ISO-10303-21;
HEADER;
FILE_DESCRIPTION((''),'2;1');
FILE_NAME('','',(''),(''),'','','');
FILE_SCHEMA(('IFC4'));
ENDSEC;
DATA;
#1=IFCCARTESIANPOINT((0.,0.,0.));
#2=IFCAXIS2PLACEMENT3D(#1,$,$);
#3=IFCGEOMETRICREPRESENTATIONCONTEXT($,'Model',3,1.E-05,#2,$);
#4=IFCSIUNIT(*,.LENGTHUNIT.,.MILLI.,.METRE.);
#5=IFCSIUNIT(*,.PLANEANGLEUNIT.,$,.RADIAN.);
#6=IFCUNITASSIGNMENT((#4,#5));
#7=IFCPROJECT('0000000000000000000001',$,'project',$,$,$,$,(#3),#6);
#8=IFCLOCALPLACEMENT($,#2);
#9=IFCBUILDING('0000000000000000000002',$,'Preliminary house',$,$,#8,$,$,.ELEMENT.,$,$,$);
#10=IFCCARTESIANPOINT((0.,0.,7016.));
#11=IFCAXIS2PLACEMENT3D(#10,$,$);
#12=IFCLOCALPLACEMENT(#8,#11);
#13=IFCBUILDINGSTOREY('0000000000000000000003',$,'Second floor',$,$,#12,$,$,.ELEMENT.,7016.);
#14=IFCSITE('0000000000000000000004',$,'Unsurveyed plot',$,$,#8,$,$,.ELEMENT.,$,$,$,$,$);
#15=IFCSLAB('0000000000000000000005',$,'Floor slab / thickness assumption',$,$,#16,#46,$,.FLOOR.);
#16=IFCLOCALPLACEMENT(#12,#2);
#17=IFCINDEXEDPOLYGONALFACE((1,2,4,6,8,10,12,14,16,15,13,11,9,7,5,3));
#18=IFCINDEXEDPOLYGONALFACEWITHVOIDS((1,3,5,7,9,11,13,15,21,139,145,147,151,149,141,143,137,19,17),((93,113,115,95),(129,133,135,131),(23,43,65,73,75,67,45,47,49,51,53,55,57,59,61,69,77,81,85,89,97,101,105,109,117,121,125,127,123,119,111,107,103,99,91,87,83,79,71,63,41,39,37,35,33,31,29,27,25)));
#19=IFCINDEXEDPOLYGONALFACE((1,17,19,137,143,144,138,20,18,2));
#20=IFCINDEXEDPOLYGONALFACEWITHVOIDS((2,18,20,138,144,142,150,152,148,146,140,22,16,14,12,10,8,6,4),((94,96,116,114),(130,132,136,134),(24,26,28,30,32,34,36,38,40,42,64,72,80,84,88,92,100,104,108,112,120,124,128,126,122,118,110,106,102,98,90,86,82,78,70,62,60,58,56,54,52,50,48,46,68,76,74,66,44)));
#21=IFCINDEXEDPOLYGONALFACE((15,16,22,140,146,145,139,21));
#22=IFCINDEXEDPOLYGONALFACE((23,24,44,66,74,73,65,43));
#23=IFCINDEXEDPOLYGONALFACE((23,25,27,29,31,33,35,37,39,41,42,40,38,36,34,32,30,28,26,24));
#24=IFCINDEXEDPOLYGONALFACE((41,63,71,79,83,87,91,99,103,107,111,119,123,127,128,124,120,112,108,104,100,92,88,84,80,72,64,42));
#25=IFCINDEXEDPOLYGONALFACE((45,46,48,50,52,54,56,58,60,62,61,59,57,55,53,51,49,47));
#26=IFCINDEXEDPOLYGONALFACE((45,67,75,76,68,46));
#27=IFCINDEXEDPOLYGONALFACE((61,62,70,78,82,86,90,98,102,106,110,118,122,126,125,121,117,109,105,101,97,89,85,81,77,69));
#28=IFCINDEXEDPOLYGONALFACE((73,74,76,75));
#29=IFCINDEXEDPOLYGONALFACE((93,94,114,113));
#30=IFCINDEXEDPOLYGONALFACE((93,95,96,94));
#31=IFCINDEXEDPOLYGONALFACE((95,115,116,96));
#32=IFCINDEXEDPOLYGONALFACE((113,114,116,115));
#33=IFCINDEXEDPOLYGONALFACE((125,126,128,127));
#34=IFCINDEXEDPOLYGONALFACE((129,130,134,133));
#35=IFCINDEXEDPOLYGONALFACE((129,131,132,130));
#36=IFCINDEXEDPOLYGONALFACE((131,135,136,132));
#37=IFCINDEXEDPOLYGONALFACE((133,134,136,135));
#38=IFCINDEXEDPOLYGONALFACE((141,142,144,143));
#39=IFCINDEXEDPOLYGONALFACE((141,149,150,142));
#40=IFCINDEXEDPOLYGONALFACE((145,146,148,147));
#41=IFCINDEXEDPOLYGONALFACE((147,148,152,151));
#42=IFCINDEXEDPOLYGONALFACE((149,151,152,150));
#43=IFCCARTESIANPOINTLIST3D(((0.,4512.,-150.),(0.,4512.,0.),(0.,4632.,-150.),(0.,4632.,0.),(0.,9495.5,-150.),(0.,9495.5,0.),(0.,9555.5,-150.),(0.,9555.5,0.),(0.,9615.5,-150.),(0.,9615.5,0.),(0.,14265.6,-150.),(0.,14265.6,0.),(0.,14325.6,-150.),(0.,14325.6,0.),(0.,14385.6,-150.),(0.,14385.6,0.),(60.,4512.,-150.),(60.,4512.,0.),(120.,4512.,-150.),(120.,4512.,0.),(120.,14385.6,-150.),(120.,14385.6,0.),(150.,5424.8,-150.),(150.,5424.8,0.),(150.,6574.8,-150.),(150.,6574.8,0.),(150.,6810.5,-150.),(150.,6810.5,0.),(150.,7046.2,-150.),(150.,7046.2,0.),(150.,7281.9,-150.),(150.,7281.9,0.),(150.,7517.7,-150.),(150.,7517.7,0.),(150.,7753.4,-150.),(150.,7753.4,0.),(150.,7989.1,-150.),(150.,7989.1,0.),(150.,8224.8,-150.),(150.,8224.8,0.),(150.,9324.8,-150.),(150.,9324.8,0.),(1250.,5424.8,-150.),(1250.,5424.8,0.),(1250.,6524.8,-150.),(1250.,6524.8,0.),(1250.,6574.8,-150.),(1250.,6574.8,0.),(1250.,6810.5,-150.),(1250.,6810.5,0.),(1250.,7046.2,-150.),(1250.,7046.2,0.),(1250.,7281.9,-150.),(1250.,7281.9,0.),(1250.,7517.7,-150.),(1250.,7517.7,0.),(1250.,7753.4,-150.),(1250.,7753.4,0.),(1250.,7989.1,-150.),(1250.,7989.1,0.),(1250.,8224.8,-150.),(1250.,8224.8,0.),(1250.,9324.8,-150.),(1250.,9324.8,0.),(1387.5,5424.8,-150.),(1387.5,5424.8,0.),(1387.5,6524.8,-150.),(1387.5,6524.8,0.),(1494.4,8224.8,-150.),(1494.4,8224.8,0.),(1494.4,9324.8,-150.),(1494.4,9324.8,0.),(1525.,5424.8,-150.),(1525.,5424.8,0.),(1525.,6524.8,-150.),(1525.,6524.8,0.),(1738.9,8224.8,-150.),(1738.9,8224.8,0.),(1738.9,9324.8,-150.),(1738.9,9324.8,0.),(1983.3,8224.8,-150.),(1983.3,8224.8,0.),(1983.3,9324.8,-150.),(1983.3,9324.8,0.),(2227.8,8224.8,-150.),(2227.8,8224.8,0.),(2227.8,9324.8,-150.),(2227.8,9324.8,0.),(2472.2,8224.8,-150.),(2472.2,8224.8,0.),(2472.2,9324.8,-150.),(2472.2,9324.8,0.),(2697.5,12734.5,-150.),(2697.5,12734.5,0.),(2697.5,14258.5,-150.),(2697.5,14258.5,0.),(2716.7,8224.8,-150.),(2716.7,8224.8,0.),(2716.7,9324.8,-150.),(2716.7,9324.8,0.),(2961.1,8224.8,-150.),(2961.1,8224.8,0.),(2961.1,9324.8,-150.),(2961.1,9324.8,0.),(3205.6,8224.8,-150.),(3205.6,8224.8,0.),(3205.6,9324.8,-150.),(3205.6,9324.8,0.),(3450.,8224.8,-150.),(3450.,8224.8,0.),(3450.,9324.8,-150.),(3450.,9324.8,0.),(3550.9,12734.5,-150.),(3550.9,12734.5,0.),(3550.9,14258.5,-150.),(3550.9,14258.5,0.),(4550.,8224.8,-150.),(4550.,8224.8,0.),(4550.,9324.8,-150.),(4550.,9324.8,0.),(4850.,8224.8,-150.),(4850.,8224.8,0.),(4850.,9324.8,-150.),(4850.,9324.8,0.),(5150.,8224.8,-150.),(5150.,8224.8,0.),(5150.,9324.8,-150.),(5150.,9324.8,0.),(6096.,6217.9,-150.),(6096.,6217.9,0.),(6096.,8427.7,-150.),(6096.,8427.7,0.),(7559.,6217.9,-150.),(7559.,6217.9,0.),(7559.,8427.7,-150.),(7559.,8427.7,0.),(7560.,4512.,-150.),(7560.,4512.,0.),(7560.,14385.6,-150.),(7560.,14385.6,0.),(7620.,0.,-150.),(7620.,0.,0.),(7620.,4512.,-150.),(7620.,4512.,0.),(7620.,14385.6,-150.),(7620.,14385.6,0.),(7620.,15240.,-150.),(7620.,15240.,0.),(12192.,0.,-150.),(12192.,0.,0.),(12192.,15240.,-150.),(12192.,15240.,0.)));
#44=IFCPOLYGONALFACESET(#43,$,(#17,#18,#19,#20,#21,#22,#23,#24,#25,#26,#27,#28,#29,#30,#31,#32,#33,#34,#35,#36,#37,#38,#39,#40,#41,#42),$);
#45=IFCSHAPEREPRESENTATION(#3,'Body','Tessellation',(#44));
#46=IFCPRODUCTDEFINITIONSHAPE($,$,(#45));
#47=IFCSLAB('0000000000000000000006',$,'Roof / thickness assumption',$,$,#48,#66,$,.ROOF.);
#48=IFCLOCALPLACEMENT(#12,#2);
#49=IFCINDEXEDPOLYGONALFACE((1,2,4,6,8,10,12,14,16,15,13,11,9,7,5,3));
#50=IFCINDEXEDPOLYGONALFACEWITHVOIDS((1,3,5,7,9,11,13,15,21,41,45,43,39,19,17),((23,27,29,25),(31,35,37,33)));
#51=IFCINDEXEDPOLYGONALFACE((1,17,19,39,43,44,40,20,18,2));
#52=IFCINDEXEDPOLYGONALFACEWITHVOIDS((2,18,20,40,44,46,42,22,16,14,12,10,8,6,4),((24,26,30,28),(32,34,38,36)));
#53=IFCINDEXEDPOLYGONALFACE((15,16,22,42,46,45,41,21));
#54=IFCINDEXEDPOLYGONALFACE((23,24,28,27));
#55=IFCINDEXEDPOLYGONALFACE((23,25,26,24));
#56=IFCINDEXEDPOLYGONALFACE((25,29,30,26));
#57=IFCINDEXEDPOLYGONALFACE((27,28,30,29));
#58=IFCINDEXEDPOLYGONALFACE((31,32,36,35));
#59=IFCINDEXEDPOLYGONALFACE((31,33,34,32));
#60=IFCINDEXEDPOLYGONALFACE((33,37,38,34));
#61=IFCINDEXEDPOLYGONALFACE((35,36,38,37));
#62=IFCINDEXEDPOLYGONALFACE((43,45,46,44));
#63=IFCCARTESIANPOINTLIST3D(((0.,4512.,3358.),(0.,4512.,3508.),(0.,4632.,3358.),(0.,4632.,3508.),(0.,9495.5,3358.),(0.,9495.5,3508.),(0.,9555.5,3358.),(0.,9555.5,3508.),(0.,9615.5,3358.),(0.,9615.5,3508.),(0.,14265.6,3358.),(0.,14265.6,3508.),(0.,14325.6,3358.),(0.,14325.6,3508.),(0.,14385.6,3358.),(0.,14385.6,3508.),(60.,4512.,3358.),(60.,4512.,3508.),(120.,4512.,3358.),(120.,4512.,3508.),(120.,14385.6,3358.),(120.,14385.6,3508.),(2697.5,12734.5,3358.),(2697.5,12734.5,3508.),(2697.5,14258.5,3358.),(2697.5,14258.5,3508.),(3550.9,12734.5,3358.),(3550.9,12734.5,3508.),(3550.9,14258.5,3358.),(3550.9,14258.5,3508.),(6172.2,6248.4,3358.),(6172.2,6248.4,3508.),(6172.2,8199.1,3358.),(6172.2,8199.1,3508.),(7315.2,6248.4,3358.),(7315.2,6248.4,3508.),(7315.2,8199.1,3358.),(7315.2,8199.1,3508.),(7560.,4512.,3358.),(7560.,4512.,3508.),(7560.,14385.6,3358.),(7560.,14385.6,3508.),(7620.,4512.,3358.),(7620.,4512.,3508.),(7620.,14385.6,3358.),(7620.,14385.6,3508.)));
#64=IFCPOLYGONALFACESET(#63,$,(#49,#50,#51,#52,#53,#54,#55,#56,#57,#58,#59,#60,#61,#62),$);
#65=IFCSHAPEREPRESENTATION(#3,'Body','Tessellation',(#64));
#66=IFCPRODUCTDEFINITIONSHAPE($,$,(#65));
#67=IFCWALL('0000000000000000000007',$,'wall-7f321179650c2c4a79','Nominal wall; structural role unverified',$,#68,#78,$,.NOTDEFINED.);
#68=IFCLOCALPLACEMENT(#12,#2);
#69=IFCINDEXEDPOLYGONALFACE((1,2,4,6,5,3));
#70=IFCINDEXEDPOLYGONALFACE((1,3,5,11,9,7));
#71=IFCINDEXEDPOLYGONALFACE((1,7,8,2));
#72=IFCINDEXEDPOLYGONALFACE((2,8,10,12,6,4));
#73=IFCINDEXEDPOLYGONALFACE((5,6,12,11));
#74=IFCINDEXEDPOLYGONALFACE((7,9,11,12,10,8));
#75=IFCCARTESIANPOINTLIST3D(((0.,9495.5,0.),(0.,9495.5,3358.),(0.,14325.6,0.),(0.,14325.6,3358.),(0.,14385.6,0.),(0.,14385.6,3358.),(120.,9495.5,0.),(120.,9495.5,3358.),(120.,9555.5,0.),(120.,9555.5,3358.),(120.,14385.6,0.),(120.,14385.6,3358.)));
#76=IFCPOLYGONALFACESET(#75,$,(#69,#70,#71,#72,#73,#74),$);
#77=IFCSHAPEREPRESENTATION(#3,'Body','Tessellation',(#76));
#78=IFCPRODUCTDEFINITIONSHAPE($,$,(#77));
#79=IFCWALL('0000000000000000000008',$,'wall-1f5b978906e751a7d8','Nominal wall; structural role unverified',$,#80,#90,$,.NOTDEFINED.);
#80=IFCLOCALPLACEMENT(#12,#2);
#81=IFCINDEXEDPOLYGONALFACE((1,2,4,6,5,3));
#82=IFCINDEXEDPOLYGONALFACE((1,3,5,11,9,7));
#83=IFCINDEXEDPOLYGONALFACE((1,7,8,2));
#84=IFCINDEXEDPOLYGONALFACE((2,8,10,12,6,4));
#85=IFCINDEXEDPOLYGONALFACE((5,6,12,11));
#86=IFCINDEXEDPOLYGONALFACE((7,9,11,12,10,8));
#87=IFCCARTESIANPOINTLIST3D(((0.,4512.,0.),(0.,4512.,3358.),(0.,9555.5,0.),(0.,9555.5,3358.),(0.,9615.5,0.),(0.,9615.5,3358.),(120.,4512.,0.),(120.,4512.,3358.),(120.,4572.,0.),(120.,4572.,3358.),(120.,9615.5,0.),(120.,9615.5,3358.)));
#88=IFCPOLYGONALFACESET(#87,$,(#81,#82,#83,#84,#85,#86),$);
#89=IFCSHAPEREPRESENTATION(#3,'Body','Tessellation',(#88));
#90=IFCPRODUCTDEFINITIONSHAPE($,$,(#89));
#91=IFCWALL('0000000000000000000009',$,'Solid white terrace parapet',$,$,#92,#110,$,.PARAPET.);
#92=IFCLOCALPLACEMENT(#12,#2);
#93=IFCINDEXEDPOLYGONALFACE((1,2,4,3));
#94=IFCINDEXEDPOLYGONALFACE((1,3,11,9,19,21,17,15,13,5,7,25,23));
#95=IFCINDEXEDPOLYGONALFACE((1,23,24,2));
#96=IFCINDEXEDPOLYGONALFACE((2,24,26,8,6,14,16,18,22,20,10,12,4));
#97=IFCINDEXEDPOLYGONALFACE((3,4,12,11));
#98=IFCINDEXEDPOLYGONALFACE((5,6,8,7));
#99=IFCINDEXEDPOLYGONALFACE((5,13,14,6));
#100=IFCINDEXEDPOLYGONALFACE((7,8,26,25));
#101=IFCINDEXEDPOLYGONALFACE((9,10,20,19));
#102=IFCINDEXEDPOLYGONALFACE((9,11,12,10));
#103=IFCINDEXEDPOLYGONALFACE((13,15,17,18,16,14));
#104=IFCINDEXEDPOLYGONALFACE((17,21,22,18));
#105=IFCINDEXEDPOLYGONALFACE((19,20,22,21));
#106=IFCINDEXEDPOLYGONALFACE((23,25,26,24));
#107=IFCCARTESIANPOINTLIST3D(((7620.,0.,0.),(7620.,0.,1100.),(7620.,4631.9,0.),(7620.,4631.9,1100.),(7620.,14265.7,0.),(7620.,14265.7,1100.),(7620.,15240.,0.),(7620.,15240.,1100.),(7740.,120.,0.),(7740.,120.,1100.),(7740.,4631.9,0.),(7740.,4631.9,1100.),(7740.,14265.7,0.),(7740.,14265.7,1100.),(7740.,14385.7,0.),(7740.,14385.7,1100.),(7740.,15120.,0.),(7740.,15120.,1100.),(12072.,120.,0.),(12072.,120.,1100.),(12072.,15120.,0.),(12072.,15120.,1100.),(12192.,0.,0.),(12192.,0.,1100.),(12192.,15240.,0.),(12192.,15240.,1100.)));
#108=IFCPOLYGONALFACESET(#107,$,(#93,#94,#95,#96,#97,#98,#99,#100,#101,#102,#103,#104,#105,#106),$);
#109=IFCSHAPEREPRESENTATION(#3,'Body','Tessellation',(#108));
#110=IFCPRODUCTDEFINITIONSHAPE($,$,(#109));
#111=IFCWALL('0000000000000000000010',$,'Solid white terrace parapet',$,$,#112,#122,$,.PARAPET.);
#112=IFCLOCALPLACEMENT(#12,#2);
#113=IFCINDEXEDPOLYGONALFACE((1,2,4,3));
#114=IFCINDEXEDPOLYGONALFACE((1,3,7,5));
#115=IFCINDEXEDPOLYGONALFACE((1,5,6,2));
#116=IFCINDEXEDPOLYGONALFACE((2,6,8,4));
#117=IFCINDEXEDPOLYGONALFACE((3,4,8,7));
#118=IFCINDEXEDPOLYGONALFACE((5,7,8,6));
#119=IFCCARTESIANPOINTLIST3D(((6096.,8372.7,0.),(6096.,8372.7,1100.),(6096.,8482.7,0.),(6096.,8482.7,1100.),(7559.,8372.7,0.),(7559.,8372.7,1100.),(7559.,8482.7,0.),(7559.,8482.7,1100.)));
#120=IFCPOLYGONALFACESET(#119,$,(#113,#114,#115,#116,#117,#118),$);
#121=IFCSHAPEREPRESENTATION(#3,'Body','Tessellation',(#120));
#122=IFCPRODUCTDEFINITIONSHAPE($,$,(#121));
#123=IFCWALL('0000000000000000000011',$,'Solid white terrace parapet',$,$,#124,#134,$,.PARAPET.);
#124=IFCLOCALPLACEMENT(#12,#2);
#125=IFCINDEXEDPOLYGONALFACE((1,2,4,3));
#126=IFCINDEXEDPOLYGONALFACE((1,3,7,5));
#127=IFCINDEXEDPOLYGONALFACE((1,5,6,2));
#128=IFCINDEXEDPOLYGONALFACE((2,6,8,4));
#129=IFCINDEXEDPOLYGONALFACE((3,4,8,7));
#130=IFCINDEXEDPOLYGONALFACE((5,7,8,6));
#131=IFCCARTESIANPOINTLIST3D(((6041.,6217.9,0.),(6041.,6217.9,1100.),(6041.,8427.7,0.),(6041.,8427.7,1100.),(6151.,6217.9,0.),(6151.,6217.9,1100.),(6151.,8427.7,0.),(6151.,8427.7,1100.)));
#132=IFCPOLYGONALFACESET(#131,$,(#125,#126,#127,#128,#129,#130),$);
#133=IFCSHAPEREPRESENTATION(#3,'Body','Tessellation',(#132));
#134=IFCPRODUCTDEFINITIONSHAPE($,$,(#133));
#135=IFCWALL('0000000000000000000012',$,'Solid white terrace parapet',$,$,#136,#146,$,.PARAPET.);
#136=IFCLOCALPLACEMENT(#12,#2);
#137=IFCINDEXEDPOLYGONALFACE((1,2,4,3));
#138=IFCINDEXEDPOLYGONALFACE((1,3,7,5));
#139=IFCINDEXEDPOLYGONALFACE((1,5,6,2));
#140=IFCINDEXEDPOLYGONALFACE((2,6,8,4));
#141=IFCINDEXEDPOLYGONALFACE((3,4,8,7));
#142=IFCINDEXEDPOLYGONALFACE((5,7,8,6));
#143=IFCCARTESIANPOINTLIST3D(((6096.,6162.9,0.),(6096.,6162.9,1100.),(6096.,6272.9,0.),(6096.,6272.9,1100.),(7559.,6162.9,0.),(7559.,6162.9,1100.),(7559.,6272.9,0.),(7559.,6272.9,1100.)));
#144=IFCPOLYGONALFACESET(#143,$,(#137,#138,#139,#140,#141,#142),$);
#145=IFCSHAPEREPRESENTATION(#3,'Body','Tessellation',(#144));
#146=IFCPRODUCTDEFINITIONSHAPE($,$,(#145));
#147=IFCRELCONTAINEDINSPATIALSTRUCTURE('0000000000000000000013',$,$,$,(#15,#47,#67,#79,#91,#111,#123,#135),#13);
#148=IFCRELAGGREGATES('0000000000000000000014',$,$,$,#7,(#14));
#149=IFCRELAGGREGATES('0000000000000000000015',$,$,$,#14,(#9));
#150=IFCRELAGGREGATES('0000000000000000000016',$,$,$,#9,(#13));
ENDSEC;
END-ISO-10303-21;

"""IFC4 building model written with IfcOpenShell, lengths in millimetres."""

from ifc_helpers import new_model, si_unit, frame, origin, place, context, project, spatial, polyline, outline, extrude, element, save


model = new_model("IFC4")

# Units and contexts
model_context = context("Model", 3, precision=1e-05, world=origin())
ifc_project = project(units=[si_unit("LENGTHUNIT", "METRE", prefix="MILLI"), si_unit("PLANEANGLEUNIT", "RADIAN")], contexts=[model_context])

# Site, building, storey
placement_1 = place(None, origin())
site = spatial("IfcSite", under=ifc_project, at=placement_1, Name="Unsurveyed plot", CompositionType="ELEMENT")
building = spatial("IfcBuilding", under=site, at=placement_1, Name="Preliminary house", CompositionType="ELEMENT")
placement_2 = place(placement_1, frame((0.0, 0.0, 7016.0)))
storey = spatial("IfcBuildingStorey", under=building, at=placement_2, Name="Second floor", CompositionType="ELEMENT", Elevation=7016.0)

# Slabs
element("IfcSlab", 1, at=placement_2, inside=storey, Name="Floor slab / thickness assumption", PredefinedType="FLOOR", context=model_context, shape_type="SweptSolid", body=[
    extrude(outline(polyline([(0.0, 4632.0), (0.0, 9495.5), (0.0, 9555.5), (0.0, 9615.5), (0.0, 14265.6), (0.0, 14325.6), (0.0, 14385.6), (120.0, 14385.6), (7560.0, 14385.6), (7620.0, 14385.6), (7620.0, 15240.0), (12192.0, 15240.0), (12192.0, 0.0), (7620.0, 0.0), (7620.0, 4512.0), (7560.0, 4512.0), (120.0, 4512.0), (60.0, 4512.0), (0.0, 4512.0), (0.0, 4632.0)]), holes=[polyline([(1250.0, 6524.8), (1250.0, 6574.8), (1250.0, 6810.5), (1250.0, 7046.2), (1250.0, 7281.9), (1250.0, 7517.7), (1250.0, 7753.4), (1250.0, 7989.1), (1250.0, 8224.8), (1494.4, 8224.8), (1738.9, 8224.8), (1983.3, 8224.8), (2227.8, 8224.8), (2472.2, 8224.8), (2716.7, 8224.8), (2961.1, 8224.8), (3205.6, 8224.8), (3450.0, 8224.8), (4550.0, 8224.8), (4850.0, 8224.8), (5150.0, 8224.8), (5150.0, 9324.8), (4850.0, 9324.8), (4550.0, 9324.8), (3450.0, 9324.8), (3205.6, 9324.8), (2961.1, 9324.8), (2716.7, 9324.8), (2472.2, 9324.8), (2227.8, 9324.8), (1983.3, 9324.8), (1738.9, 9324.8), (1494.4, 9324.8), (1250.0, 9324.8), (150.0, 9324.8), (150.0, 8224.8), (150.0, 7989.1), (150.0, 7753.4), (150.0, 7517.7), (150.0, 7281.9), (150.0, 7046.2), (150.0, 6810.5), (150.0, 6574.8), (150.0, 5424.8), (1250.0, 5424.8), (1387.5, 5424.8), (1525.0, 5424.8), (1525.0, 6524.8), (1387.5, 6524.8), (1250.0, 6524.8)]), polyline([(6096.0, 8427.7), (6096.0, 6217.9), (7559.0, 6217.9), (7559.0, 8427.7), (6096.0, 8427.7)]), polyline([(3550.9, 14258.5), (2697.5, 14258.5), (2697.5, 12734.5), (3550.9, 12734.5), (3550.9, 14258.5)])]), frame((0.0, 0.0, -150.0)), (0.0, 0.0, 1.0), 150.0),
])
element("IfcSlab", 2, at=placement_2, inside=storey, Name="Roof / thickness assumption", PredefinedType="ROOF", context=model_context, shape_type="SweptSolid", body=[
    extrude(outline(polyline([(0.0, 4632.0), (0.0, 9495.5), (0.0, 9555.5), (0.0, 9615.5), (0.0, 14265.6), (0.0, 14325.6), (0.0, 14385.6), (120.0, 14385.6), (7560.0, 14385.6), (7620.0, 14385.6), (7620.0, 4512.0), (7560.0, 4512.0), (120.0, 4512.0), (60.0, 4512.0), (0.0, 4512.0), (0.0, 4632.0)]), holes=[polyline([(6172.2, 8199.1), (6172.2, 6248.4), (7315.2, 6248.4), (7315.2, 8199.1), (6172.2, 8199.1)]), polyline([(3550.9, 14258.5), (2697.5, 14258.5), (2697.5, 12734.5), (3550.9, 12734.5), (3550.9, 14258.5)])]), frame((0.0, 0.0, 3358.0)), (0.0, 0.0, 1.0), 150.0),
])

# Wall
element("IfcWall", 3, at=placement_2, inside=storey, Name="wall-7f321179650c2c4a79", Description="Nominal wall; structural role unverified", PredefinedType="NOTDEFINED", context=model_context, shape_type="SweptSolid", body=[
    extrude(outline(polyline([(0.0, 14325.6), (0.0, 14385.6), (120.0, 14385.6), (120.0, 9555.5), (120.0, 9495.5), (0.0, 9495.5), (0.0, 14325.6)])), origin(), (0.0, 0.0, 1.0), 3358.0),
])

# Wall
element("IfcWall", 4, at=placement_2, inside=storey, Name="wall-1f5b978906e751a7d8", Description="Nominal wall; structural role unverified", PredefinedType="NOTDEFINED", context=model_context, shape_type="SweptSolid", body=[
    extrude(outline(polyline([(0.0, 9555.5), (0.0, 9615.5), (120.0, 9615.5), (120.0, 4572.0), (120.0, 4512.0), (0.0, 4512.0), (0.0, 9555.5)])), origin(), (0.0, 0.0, 1.0), 3358.0),
])

# Walls
element("IfcWall", 5, at=placement_2, inside=storey, Name="Solid white terrace parapet", PredefinedType="PARAPET", context=model_context, shape_type="SweptSolid", body=[
    extrude(outline(polyline([(7740.0, 4631.9), (7740.0, 120.0), (12072.0, 120.0), (12072.0, 15120.0), (7740.0, 15120.0), (7740.0, 14385.7), (7740.0, 14265.7), (7620.0, 14265.7), (7620.0, 15240.0), (12192.0, 15240.0), (12192.0, 0.0), (7620.0, 0.0), (7620.0, 4631.9), (7740.0, 4631.9)])), origin(), (0.0, 0.0, 1.0), 1100.0),
])
element("IfcWall", 6, at=placement_2, inside=storey, Name="Solid white terrace parapet", PredefinedType="PARAPET", context=model_context, shape_type="SweptSolid", body=[
    extrude(outline(polyline([(6096.0, 8372.7), (6096.0, 8482.7), (7559.0, 8482.7), (7559.0, 8372.7), (6096.0, 8372.7)])), origin(), (0.0, 0.0, 1.0), 1100.0),
])
element("IfcWall", 7, at=placement_2, inside=storey, Name="Solid white terrace parapet", PredefinedType="PARAPET", context=model_context, shape_type="SweptSolid", body=[
    extrude(outline(polyline([(6151.0, 6217.9), (6041.0, 6217.9), (6041.0, 8427.7), (6151.0, 8427.7), (6151.0, 6217.9)])), origin(), (0.0, 0.0, 1.0), 1100.0),
])
element("IfcWall", 8, at=placement_2, inside=storey, Name="Solid white terrace parapet", PredefinedType="PARAPET", context=model_context, shape_type="SweptSolid", body=[
    extrude(outline(polyline([(7559.0, 6272.9), (7559.0, 6162.9), (6096.0, 6162.9), (6096.0, 6272.9), (7559.0, 6272.9)])), origin(), (0.0, 0.0, 1.0), 1100.0),
])

save(model, "model.ifc")
